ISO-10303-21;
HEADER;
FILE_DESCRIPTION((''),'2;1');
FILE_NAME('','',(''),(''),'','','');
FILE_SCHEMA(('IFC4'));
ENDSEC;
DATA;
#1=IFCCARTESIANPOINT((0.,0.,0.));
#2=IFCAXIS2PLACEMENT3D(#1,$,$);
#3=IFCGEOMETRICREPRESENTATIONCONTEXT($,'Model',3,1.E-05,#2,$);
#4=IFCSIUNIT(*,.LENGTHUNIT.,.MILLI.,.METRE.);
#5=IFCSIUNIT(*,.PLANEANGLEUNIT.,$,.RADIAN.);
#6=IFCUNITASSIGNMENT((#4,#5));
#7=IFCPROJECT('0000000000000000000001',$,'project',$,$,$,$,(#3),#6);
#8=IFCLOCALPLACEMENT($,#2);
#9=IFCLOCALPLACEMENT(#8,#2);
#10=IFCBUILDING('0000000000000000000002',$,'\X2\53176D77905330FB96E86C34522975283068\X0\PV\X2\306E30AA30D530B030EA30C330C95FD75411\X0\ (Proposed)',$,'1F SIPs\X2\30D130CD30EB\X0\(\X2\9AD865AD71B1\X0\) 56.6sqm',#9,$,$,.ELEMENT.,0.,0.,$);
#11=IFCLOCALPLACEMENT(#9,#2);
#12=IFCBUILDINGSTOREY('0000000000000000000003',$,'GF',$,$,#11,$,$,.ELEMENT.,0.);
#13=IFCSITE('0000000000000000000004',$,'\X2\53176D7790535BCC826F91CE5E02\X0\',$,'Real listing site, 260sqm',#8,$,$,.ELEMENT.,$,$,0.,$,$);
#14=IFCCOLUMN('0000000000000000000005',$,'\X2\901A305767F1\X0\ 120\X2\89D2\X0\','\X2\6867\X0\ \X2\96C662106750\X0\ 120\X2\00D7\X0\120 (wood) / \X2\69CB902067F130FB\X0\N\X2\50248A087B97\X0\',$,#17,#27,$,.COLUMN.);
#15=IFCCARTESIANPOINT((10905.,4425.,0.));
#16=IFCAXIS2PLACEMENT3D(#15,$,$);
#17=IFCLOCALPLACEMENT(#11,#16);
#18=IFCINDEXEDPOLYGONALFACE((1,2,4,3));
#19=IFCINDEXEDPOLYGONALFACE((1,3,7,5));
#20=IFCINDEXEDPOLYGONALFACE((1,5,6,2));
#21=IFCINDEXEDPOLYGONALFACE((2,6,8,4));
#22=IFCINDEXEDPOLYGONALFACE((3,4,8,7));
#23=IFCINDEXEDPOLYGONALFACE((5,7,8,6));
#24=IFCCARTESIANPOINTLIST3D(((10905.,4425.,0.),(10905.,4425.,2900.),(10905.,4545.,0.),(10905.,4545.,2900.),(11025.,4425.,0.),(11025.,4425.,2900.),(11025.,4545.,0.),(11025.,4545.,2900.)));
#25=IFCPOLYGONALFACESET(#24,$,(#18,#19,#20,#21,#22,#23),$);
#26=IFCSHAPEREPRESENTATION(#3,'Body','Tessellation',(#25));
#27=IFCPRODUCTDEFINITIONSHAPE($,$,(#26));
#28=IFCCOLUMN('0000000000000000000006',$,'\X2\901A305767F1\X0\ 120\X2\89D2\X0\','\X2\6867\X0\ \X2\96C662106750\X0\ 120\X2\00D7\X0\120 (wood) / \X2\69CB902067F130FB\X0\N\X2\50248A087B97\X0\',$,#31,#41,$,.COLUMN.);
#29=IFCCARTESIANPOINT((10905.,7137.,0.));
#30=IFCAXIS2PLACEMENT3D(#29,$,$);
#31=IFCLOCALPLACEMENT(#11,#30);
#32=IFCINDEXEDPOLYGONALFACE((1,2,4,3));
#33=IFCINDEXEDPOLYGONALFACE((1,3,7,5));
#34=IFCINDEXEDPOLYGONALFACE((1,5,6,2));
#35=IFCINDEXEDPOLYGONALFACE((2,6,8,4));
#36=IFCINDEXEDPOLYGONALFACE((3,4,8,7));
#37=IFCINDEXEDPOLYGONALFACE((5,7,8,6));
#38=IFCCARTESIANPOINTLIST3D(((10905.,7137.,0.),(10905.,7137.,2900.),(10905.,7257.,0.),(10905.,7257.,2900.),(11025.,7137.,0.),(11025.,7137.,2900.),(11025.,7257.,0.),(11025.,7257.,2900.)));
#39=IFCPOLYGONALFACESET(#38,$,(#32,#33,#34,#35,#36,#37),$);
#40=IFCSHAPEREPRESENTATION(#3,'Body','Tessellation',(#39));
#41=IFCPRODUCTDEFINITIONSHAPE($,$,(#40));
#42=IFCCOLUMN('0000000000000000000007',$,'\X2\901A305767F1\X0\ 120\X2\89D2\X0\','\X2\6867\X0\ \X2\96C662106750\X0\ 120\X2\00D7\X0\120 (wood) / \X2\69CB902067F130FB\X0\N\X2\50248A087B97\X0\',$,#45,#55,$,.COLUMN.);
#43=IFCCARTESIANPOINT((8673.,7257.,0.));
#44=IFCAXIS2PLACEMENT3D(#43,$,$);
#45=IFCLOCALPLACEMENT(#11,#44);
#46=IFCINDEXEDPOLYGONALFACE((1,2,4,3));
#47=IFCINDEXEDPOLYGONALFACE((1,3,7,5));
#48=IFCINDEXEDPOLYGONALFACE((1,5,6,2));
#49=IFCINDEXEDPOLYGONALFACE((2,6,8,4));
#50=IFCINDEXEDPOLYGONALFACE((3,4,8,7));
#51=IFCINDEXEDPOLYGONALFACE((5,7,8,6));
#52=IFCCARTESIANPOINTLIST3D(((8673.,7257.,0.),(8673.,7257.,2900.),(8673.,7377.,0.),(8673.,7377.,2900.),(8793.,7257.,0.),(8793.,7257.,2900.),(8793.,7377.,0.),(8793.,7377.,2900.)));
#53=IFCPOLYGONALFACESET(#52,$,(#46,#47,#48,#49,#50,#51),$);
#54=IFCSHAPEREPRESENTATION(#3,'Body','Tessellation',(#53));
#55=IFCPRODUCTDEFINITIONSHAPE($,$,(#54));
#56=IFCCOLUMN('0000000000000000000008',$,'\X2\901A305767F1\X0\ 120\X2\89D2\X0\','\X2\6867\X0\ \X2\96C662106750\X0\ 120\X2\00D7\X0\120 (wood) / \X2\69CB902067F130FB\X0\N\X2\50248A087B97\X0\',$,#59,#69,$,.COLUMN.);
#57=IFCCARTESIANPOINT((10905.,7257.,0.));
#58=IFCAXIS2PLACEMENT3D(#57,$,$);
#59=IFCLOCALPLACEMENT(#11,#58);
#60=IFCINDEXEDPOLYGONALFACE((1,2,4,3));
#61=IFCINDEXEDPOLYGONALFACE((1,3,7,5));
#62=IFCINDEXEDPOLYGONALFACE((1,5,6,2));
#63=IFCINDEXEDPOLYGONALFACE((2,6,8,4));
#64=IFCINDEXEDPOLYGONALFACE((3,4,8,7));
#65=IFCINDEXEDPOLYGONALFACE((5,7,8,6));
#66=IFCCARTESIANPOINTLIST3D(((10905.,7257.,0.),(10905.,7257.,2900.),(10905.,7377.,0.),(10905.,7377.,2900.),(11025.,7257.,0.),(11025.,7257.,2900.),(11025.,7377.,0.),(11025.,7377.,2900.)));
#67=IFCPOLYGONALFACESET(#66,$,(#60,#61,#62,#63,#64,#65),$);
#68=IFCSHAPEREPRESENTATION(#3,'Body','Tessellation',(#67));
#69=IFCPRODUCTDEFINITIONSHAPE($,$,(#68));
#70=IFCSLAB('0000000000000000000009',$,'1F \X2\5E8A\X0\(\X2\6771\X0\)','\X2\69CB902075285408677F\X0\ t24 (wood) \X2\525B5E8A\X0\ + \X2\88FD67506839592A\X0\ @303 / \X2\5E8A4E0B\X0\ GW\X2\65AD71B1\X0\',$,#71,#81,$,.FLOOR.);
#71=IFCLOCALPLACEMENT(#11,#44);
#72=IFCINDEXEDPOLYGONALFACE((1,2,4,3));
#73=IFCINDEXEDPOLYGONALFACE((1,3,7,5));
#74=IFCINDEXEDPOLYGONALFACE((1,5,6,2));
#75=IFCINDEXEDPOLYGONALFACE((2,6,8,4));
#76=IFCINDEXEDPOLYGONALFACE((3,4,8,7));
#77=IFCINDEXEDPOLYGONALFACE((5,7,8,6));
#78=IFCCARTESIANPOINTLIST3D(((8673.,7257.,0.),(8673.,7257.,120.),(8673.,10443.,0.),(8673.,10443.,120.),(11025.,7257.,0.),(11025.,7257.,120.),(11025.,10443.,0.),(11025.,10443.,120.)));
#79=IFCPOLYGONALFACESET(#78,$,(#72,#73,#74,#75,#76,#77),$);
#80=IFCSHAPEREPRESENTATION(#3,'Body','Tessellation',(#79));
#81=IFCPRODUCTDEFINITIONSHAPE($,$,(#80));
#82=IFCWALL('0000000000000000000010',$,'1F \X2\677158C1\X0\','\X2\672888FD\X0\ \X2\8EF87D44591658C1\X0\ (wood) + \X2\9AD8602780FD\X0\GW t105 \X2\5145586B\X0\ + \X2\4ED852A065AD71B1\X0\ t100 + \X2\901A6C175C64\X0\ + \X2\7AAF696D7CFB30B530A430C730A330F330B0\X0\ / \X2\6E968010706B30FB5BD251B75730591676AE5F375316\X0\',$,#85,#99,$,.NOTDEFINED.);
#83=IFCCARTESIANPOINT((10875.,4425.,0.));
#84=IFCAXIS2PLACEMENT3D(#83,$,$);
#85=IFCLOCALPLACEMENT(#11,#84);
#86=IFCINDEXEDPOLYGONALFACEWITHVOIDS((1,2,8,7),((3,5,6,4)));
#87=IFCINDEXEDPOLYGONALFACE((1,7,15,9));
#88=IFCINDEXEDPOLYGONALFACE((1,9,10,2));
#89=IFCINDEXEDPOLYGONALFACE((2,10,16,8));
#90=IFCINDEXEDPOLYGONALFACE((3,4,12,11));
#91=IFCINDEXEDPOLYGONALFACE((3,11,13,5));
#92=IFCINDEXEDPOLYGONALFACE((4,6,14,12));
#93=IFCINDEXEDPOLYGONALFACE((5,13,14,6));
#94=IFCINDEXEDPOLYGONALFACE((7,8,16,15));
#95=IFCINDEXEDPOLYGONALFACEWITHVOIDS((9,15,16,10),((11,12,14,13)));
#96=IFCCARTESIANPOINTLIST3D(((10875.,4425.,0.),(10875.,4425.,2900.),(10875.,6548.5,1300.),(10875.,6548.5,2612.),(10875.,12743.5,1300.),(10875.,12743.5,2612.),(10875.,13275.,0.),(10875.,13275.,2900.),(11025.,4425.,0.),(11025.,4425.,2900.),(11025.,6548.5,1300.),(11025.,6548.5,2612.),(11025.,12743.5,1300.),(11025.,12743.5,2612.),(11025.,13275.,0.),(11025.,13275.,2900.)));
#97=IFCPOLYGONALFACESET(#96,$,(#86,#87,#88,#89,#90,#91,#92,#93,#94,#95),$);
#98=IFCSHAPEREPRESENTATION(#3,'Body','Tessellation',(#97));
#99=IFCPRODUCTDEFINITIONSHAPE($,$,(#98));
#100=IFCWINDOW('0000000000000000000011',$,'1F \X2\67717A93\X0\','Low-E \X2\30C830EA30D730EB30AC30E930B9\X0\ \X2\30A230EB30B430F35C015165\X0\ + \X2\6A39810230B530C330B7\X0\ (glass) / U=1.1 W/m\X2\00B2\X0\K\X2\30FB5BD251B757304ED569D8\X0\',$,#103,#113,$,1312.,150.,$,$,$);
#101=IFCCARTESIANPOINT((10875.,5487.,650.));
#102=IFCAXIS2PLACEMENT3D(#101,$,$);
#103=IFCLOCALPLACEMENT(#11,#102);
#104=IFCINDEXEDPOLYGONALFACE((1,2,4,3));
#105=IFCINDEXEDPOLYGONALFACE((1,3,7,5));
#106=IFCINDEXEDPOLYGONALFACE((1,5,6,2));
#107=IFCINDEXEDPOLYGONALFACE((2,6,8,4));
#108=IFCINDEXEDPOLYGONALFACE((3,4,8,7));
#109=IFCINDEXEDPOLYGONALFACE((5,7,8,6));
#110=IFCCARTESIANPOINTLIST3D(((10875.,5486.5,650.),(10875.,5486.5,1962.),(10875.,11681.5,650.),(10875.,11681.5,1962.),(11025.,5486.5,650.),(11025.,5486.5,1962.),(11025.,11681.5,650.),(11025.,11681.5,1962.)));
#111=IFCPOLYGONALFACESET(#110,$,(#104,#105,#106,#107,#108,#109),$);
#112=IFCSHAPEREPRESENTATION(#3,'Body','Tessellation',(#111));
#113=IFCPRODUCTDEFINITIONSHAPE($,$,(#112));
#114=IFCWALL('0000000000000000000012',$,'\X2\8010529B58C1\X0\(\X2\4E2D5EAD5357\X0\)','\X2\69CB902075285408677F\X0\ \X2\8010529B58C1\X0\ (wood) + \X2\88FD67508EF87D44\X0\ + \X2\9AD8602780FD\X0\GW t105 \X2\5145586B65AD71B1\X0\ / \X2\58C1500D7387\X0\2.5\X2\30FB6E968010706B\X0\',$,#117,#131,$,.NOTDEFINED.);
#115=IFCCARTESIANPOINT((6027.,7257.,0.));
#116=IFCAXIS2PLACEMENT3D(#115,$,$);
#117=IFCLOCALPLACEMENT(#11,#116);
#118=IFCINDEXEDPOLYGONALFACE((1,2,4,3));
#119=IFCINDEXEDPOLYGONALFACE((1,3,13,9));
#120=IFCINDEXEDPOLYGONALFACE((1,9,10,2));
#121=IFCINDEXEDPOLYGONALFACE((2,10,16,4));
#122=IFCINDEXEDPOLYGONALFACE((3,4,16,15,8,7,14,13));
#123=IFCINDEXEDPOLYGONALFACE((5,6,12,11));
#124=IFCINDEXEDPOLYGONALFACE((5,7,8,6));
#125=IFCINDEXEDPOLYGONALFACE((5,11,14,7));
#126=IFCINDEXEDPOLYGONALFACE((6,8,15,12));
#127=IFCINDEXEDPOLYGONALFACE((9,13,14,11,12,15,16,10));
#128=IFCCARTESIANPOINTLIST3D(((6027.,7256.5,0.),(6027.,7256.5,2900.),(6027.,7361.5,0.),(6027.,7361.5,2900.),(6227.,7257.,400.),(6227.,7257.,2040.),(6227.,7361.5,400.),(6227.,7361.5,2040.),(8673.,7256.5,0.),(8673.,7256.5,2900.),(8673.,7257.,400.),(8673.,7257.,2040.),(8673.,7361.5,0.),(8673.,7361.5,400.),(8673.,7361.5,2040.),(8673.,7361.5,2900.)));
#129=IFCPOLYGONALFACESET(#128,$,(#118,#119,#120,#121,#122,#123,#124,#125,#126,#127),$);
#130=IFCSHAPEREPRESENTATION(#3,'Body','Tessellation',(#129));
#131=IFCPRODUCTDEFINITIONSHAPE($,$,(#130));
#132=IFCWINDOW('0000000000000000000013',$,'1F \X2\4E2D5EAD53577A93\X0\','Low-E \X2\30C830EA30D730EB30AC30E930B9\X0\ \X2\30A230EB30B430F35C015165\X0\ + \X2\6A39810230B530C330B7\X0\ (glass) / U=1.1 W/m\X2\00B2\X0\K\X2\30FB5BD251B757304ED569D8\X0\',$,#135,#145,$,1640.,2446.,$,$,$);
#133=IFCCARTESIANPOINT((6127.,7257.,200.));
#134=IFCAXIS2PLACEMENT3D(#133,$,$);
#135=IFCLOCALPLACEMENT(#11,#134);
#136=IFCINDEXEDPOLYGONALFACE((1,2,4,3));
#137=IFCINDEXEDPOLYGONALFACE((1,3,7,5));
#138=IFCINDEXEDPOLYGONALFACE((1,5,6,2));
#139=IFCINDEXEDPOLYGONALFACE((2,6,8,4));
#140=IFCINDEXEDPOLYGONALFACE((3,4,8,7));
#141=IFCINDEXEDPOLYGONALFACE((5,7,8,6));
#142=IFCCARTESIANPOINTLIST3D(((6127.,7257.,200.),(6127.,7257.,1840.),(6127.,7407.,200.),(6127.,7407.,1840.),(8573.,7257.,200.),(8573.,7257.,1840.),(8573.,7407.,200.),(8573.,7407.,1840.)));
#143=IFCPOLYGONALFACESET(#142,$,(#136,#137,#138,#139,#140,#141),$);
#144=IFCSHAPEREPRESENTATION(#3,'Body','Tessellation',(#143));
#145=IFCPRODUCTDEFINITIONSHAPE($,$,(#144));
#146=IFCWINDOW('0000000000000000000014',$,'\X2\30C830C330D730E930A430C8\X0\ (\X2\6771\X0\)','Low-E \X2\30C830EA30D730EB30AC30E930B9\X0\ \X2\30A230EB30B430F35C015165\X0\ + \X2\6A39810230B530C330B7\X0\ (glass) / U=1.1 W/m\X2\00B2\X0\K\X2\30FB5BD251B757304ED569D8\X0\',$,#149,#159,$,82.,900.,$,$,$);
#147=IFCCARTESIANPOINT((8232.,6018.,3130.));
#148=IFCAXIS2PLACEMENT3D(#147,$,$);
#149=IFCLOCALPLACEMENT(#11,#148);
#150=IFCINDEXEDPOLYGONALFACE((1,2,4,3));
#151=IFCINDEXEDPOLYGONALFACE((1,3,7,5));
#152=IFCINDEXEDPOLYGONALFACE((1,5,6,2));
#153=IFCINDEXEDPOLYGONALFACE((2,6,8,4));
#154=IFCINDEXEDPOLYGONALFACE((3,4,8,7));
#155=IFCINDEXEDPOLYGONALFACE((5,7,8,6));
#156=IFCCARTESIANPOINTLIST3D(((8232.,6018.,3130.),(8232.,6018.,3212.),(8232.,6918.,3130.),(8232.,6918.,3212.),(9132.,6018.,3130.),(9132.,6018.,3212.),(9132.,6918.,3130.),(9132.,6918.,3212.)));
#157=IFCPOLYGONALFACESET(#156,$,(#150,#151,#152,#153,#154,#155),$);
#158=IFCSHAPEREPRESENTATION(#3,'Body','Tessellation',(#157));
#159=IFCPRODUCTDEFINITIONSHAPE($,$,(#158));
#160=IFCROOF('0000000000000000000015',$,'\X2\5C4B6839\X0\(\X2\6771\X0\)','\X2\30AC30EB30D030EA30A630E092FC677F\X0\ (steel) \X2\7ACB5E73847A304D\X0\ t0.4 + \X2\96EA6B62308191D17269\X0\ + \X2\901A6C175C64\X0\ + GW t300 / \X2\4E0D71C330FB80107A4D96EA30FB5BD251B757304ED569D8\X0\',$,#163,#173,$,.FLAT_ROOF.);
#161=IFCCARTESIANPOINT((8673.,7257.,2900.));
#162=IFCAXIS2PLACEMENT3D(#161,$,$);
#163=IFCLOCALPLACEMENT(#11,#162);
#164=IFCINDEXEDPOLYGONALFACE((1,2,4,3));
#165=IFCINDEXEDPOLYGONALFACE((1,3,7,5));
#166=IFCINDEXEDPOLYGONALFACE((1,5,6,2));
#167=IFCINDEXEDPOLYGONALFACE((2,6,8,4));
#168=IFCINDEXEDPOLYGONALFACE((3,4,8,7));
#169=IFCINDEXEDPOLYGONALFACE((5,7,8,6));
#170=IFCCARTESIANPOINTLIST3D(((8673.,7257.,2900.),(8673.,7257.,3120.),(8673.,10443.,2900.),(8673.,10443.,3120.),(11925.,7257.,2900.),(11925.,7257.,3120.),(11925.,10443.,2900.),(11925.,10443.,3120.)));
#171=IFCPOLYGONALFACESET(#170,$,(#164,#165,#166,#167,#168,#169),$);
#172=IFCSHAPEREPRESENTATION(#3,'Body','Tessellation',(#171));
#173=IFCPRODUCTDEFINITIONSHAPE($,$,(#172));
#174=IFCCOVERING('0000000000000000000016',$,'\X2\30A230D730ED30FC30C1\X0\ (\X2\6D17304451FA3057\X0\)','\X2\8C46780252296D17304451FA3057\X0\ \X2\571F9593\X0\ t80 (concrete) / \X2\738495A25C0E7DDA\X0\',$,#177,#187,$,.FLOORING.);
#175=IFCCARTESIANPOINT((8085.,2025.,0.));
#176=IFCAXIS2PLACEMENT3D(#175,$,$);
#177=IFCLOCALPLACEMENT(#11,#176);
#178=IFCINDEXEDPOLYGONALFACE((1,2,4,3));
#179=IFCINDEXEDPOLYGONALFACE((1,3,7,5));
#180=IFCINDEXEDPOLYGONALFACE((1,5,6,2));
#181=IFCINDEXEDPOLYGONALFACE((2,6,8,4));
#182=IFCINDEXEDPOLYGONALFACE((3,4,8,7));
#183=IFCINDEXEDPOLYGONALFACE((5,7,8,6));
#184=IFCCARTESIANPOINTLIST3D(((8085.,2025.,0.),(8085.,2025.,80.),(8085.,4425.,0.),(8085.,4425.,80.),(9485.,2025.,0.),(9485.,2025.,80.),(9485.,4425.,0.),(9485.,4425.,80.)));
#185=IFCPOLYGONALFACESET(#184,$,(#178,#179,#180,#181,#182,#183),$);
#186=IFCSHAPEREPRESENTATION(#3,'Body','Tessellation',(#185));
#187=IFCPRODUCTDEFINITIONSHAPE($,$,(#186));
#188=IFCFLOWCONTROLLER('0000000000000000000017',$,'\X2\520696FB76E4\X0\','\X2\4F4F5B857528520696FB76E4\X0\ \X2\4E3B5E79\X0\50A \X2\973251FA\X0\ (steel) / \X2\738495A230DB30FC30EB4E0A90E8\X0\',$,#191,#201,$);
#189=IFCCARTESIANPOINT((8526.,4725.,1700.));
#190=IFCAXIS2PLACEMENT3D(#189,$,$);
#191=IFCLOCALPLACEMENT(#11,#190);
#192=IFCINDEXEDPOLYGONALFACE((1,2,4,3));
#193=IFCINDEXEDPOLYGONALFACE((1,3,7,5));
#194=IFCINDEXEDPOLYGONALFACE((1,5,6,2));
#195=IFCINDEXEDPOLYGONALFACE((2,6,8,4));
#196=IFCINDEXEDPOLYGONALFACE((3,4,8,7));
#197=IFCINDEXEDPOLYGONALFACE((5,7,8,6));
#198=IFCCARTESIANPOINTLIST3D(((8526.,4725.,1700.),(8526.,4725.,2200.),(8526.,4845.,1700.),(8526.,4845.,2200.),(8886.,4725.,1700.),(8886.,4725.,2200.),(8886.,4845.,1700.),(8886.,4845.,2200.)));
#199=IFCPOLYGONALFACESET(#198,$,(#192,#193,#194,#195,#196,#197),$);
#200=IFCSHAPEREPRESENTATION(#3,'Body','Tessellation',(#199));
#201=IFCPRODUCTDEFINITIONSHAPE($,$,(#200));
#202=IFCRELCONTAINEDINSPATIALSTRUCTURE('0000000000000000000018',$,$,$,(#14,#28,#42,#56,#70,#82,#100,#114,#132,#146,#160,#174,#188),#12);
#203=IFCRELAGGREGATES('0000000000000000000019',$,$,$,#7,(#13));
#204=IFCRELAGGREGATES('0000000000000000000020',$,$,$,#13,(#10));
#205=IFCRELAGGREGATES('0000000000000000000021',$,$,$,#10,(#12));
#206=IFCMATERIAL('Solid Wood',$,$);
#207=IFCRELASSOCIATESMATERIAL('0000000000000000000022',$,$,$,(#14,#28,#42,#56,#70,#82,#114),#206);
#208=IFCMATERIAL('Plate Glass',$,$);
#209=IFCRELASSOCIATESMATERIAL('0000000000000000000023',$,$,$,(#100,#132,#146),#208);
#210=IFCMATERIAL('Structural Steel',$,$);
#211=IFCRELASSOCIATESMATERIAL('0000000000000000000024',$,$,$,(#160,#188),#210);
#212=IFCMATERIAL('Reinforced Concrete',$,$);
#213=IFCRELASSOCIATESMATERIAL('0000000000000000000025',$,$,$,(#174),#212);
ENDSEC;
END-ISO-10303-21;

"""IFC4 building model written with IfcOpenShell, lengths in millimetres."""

from ifc_helpers import new_model, si_unit, frame, frame_2d, origin, place, context, project, spatial, rectangle, extrude, material, element, fill, save


model = new_model("IFC4")

# Units and contexts
model_context = context("Model", 3, precision=1e-05, world=origin())
ifc_project = project(units=[si_unit("LENGTHUNIT", "METRE", prefix="MILLI"), si_unit("PLANEANGLEUNIT", "RADIAN")], contexts=[model_context])

# Site, building, storey
site_placement = place(None, origin())
site = spatial("IfcSite", under=ifc_project, at=site_placement, Name="北海道富良野市", ObjectType="Real listing site, 260sqm", CompositionType="ELEMENT", RefElevation=0.0)
building_placement = place(site_placement, origin())
building = spatial("IfcBuilding", under=site, at=building_placement, Name="北海道・雨水利用とPVのオフグリッド志向 (Proposed)", ObjectType="1F SIPsパネル(高断熱) 56.6sqm", CompositionType="ELEMENT", ElevationOfRefHeight=0.0, ElevationOfTerrain=0.0)
storey_placement = place(building_placement, origin())
storey = spatial("IfcBuildingStorey", under=building, at=storey_placement, Name="GF", CompositionType="ELEMENT", Elevation=0.0)

# Columns
ifc_material_1 = material(Name="Solid Wood")
column_1_placement = place(storey_placement, frame((10905.0, 4425.0, 0.0)))
element("IfcColumn", 1, at=column_1_placement, inside=storey, material=ifc_material_1, Name="通し柱 120角", Description="桧 集成材 120×120 (wood) / 構造柱・N値計算", PredefinedType="COLUMN", context=model_context, shape_type="SweptSolid", body=[
    extrude(rectangle(XDim=120.0, YDim=120.0, at=frame_2d((60.0, 60.0))), frame((10905.0, 4425.0, 0.0)), (0.0, 0.0, 1.0), 2900.0),
])
column_2_placement = place(storey_placement, frame((10905.0, 7137.0, 0.0)))
element("IfcColumn", 2, at=column_2_placement, inside=storey, material=ifc_material_1, Name="通し柱 120角", Description="桧 集成材 120×120 (wood) / 構造柱・N値計算", PredefinedType="COLUMN", context=model_context, shape_type="SweptSolid", body=[
    extrude(rectangle(XDim=120.0, YDim=120.0, at=frame_2d((60.0, 60.0))), frame((10905.0, 7137.0, 0.0)), (0.0, 0.0, 1.0), 2900.0),
])
column_3_placement = place(storey_placement, frame((8673.0, 7257.0, 0.0)))
element("IfcColumn", 3, at=column_3_placement, inside=storey, material=ifc_material_1, Name="通し柱 120角", Description="桧 集成材 120×120 (wood) / 構造柱・N値計算", PredefinedType="COLUMN", context=model_context, shape_type="SweptSolid", body=[
    extrude(rectangle(XDim=120.0, YDim=120.0, at=frame_2d((60.0, 60.0))), frame((8673.0, 7257.0, 0.0)), (0.0, 0.0, 1.0), 2900.0),
])
column_4_placement = place(storey_placement, frame((10905.0, 7257.0, 0.0)))
element("IfcColumn", 4, at=column_4_placement, inside=storey, material=ifc_material_1, Name="通し柱 120角", Description="桧 集成材 120×120 (wood) / 構造柱・N値計算", PredefinedType="COLUMN", context=model_context, shape_type="SweptSolid", body=[
    extrude(rectangle(XDim=120.0, YDim=120.0, at=frame_2d((60.0, 60.0))), frame((10905.0, 7257.0, 0.0)), (0.0, 0.0, 1.0), 2900.0),
])

# Slab
slab_placement = place(storey_placement, frame((8673.0, 7257.0, 0.0)))
element("IfcSlab", 5, at=slab_placement, inside=storey, material=ifc_material_1, Name="1F 床(東)", Description="構造用合板 t24 (wood) 剛床 + 製材根太 @303 / 床下 GW断熱", PredefinedType="FLOOR", context=model_context, shape_type="SweptSolid", body=[
    extrude(rectangle(XDim=2352.0, YDim=3186.0, at=frame_2d((1176.0, 1593.0))), frame((8673.0, 7257.0, 0.0)), (0.0, 0.0, 1.0), 120.0),
])

# Walls, openings, windows
wall_1_placement = place(storey_placement, frame((10875.0, 4425.0, 0.0)))
wall_1 = element("IfcWall", 6, at=wall_1_placement, inside=storey, material=ifc_material_1, Name="1F 東壁", Description="木製 軸組外壁 (wood) + 高性能GW t105 充填 + 付加断熱 t100 + 通気層 + 窯業系サイディング / 準耐火・寒冷地外皮強化", PredefinedType="NOTDEFINED", context=model_context, shape_type="SweptSolid", body=[
    extrude(rectangle(XDim=150.0, YDim=8850.0, at=frame_2d((75.0, 4425.0))), frame((10875.0, 4425.0, 0.0)), (0.0, 0.0, 1.0), 2900.0),
])
opening_1_placement = place(storey_placement, frame((10875.0, 5487.0, 650.0)))
opening_1 = element("IfcOpeningElement", 7, at=opening_1_placement, cuts=wall_1, PredefinedType="NOTDEFINED", context=model_context, shape_type="SweptSolid", body=[
    extrude(rectangle(XDim=150.0, YDim=6195.0, at=frame_2d((75.0, 3097.0))), frame((10875.0, 5487.0, 650.0)), (0.0, 0.0, 1.0), 1312.0),
])
ifc_material_2 = material(Name="Plate Glass")
window_1_placement = place(storey_placement, frame((10875.0, 5487.0, 650.0)))
window_1 = element("IfcWindow", 8, at=window_1_placement, inside=storey, material=ifc_material_2, Name="1F 東窓", Description="Low-E トリプルガラス アルゴン封入 + 樹脂サッシ (glass) / U=1.1 W/m²K・寒冷地仕様", OverallHeight=1312.0, OverallWidth=150.0, context=model_context, shape_type="SweptSolid", body=[
    extrude(rectangle(XDim=150.0, YDim=6195.0, at=frame_2d((75.0, 3097.0))), frame((10875.0, 5487.0, 650.0)), (0.0, 0.0, 1.0), 1312.0),
])
fill(opening_1, window_1)
wall_2_placement = place(storey_placement, frame((6027.0, 7257.0, 0.0)))
wall_2 = element("IfcWall", 9, at=wall_2_placement, inside=storey, material=ifc_material_1, Name="耐力壁(中庭南)", Description="構造用合板 耐力壁 (wood) + 製材軸組 + 高性能GW t105 充填断熱 / 壁倍率2.5・準耐火", PredefinedType="NOTDEFINED", context=model_context, shape_type="SweptSolid", body=[
    extrude(rectangle(XDim=2646.0, YDim=105.0, at=frame_2d((1323.0, 52.0))), frame((6027.0, 7257.0, 0.0)), (0.0, 0.0, 1.0), 2900.0),
])
opening_2_placement = place(storey_placement, frame((6127.0, 7257.0, 200.0)))
opening_2 = element("IfcOpeningElement", 10, at=opening_2_placement, cuts=wall_2, PredefinedType="NOTDEFINED", context=model_context, shape_type="SweptSolid", body=[
    extrude(rectangle(XDim=2446.0, YDim=150.0, at=frame_2d((1223.0, 75.0))), frame((6127.0, 7257.0, 200.0)), (0.0, 0.0, 1.0), 1640.0),
])
window_2_placement = place(storey_placement, frame((6127.0, 7257.0, 200.0)))
window_2 = element("IfcWindow", 11, at=window_2_placement, inside=storey, material=ifc_material_2, Name="1F 中庭南窓", Description="Low-E トリプルガラス アルゴン封入 + 樹脂サッシ (glass) / U=1.1 W/m²K・寒冷地仕様", OverallHeight=1640.0, OverallWidth=2446.0, context=model_context, shape_type="SweptSolid", body=[
    extrude(rectangle(XDim=2446.0, YDim=150.0, at=frame_2d((1223.0, 75.0))), frame((6127.0, 7257.0, 200.0)), (0.0, 0.0, 1.0), 1640.0),
])
fill(opening_2, window_2)

# Window
window_3_placement = place(storey_placement, frame((8232.0, 6018.0, 3130.0)))
element("IfcWindow", 12, at=window_3_placement, inside=storey, material=ifc_material_2, Name="トップライト (東)", Description="Low-E トリプルガラス アルゴン封入 + 樹脂サッシ (glass) / U=1.1 W/m²K・寒冷地仕様", OverallHeight=82.0, OverallWidth=900.0, context=model_context, shape_type="SweptSolid", body=[
    extrude(rectangle(XDim=900.0, YDim=900.0, at=frame_2d((450.0, 450.0))), frame((8232.0, 6018.0, 3130.0)), (0.0, 0.0, 1.0), 82.0),
])

# Roof
ifc_material_3 = material(Name="Structural Steel")
roof_placement = place(storey_placement, frame((8673.0, 7257.0, 2900.0)))
element("IfcRoof", 13, at=roof_placement, inside=storey, material=ifc_material_3, Name="屋根(東)", Description="ガルバリウム鋼板 (steel) 立平葺き t0.4 + 雪止め金物 + 通気層 + GW t300 / 不燃・耐積雪・寒冷地仕様", PredefinedType="FLAT_ROOF", context=model_context, shape_type="SweptSolid", body=[
    extrude(rectangle(XDim=3252.0, YDim=3186.0, at=frame_2d((1626.0, 1593.0))), frame((8673.0, 7257.0, 2900.0)), (0.0, 0.0, 1.0), 220.0),
])

# Covering
ifc_material_4 = material(Name="Reinforced Concrete")
covering_placement = place(storey_placement, frame((8085.0, 2025.0, 0.0)))
element("IfcCovering", 14, at=covering_placement, inside=storey, material=ifc_material_4, Name="アプローチ (洗い出し)", Description="豆砂利洗い出し 土間 t80 (concrete) / 玄関導線", PredefinedType="FLOORING", context=model_context, shape_type="SweptSolid", body=[
    extrude(rectangle(XDim=1400.0, YDim=2400.0, at=frame_2d((700.0, 1200.0))), frame((8085.0, 2025.0, 0.0)), (0.0, 0.0, 1.0), 80.0),
])

# Flow controller
flow_controller_placement = place(storey_placement, frame((8526.0, 4725.0, 1700.0)))
element("IfcFlowController", 15, at=flow_controller_placement, inside=storey, material=ifc_material_3, Name="分電盤", Description="住宅用分電盤 主幹50A 露出 (steel) / 玄関ホール上部", context=model_context, shape_type="SweptSolid", body=[
    extrude(rectangle(XDim=360.0, YDim=120.0, at=frame_2d((180.0, 60.0))), frame((8526.0, 4725.0, 1700.0)), (0.0, 0.0, 1.0), 500.0),
])

save(model, "model.ifc")
